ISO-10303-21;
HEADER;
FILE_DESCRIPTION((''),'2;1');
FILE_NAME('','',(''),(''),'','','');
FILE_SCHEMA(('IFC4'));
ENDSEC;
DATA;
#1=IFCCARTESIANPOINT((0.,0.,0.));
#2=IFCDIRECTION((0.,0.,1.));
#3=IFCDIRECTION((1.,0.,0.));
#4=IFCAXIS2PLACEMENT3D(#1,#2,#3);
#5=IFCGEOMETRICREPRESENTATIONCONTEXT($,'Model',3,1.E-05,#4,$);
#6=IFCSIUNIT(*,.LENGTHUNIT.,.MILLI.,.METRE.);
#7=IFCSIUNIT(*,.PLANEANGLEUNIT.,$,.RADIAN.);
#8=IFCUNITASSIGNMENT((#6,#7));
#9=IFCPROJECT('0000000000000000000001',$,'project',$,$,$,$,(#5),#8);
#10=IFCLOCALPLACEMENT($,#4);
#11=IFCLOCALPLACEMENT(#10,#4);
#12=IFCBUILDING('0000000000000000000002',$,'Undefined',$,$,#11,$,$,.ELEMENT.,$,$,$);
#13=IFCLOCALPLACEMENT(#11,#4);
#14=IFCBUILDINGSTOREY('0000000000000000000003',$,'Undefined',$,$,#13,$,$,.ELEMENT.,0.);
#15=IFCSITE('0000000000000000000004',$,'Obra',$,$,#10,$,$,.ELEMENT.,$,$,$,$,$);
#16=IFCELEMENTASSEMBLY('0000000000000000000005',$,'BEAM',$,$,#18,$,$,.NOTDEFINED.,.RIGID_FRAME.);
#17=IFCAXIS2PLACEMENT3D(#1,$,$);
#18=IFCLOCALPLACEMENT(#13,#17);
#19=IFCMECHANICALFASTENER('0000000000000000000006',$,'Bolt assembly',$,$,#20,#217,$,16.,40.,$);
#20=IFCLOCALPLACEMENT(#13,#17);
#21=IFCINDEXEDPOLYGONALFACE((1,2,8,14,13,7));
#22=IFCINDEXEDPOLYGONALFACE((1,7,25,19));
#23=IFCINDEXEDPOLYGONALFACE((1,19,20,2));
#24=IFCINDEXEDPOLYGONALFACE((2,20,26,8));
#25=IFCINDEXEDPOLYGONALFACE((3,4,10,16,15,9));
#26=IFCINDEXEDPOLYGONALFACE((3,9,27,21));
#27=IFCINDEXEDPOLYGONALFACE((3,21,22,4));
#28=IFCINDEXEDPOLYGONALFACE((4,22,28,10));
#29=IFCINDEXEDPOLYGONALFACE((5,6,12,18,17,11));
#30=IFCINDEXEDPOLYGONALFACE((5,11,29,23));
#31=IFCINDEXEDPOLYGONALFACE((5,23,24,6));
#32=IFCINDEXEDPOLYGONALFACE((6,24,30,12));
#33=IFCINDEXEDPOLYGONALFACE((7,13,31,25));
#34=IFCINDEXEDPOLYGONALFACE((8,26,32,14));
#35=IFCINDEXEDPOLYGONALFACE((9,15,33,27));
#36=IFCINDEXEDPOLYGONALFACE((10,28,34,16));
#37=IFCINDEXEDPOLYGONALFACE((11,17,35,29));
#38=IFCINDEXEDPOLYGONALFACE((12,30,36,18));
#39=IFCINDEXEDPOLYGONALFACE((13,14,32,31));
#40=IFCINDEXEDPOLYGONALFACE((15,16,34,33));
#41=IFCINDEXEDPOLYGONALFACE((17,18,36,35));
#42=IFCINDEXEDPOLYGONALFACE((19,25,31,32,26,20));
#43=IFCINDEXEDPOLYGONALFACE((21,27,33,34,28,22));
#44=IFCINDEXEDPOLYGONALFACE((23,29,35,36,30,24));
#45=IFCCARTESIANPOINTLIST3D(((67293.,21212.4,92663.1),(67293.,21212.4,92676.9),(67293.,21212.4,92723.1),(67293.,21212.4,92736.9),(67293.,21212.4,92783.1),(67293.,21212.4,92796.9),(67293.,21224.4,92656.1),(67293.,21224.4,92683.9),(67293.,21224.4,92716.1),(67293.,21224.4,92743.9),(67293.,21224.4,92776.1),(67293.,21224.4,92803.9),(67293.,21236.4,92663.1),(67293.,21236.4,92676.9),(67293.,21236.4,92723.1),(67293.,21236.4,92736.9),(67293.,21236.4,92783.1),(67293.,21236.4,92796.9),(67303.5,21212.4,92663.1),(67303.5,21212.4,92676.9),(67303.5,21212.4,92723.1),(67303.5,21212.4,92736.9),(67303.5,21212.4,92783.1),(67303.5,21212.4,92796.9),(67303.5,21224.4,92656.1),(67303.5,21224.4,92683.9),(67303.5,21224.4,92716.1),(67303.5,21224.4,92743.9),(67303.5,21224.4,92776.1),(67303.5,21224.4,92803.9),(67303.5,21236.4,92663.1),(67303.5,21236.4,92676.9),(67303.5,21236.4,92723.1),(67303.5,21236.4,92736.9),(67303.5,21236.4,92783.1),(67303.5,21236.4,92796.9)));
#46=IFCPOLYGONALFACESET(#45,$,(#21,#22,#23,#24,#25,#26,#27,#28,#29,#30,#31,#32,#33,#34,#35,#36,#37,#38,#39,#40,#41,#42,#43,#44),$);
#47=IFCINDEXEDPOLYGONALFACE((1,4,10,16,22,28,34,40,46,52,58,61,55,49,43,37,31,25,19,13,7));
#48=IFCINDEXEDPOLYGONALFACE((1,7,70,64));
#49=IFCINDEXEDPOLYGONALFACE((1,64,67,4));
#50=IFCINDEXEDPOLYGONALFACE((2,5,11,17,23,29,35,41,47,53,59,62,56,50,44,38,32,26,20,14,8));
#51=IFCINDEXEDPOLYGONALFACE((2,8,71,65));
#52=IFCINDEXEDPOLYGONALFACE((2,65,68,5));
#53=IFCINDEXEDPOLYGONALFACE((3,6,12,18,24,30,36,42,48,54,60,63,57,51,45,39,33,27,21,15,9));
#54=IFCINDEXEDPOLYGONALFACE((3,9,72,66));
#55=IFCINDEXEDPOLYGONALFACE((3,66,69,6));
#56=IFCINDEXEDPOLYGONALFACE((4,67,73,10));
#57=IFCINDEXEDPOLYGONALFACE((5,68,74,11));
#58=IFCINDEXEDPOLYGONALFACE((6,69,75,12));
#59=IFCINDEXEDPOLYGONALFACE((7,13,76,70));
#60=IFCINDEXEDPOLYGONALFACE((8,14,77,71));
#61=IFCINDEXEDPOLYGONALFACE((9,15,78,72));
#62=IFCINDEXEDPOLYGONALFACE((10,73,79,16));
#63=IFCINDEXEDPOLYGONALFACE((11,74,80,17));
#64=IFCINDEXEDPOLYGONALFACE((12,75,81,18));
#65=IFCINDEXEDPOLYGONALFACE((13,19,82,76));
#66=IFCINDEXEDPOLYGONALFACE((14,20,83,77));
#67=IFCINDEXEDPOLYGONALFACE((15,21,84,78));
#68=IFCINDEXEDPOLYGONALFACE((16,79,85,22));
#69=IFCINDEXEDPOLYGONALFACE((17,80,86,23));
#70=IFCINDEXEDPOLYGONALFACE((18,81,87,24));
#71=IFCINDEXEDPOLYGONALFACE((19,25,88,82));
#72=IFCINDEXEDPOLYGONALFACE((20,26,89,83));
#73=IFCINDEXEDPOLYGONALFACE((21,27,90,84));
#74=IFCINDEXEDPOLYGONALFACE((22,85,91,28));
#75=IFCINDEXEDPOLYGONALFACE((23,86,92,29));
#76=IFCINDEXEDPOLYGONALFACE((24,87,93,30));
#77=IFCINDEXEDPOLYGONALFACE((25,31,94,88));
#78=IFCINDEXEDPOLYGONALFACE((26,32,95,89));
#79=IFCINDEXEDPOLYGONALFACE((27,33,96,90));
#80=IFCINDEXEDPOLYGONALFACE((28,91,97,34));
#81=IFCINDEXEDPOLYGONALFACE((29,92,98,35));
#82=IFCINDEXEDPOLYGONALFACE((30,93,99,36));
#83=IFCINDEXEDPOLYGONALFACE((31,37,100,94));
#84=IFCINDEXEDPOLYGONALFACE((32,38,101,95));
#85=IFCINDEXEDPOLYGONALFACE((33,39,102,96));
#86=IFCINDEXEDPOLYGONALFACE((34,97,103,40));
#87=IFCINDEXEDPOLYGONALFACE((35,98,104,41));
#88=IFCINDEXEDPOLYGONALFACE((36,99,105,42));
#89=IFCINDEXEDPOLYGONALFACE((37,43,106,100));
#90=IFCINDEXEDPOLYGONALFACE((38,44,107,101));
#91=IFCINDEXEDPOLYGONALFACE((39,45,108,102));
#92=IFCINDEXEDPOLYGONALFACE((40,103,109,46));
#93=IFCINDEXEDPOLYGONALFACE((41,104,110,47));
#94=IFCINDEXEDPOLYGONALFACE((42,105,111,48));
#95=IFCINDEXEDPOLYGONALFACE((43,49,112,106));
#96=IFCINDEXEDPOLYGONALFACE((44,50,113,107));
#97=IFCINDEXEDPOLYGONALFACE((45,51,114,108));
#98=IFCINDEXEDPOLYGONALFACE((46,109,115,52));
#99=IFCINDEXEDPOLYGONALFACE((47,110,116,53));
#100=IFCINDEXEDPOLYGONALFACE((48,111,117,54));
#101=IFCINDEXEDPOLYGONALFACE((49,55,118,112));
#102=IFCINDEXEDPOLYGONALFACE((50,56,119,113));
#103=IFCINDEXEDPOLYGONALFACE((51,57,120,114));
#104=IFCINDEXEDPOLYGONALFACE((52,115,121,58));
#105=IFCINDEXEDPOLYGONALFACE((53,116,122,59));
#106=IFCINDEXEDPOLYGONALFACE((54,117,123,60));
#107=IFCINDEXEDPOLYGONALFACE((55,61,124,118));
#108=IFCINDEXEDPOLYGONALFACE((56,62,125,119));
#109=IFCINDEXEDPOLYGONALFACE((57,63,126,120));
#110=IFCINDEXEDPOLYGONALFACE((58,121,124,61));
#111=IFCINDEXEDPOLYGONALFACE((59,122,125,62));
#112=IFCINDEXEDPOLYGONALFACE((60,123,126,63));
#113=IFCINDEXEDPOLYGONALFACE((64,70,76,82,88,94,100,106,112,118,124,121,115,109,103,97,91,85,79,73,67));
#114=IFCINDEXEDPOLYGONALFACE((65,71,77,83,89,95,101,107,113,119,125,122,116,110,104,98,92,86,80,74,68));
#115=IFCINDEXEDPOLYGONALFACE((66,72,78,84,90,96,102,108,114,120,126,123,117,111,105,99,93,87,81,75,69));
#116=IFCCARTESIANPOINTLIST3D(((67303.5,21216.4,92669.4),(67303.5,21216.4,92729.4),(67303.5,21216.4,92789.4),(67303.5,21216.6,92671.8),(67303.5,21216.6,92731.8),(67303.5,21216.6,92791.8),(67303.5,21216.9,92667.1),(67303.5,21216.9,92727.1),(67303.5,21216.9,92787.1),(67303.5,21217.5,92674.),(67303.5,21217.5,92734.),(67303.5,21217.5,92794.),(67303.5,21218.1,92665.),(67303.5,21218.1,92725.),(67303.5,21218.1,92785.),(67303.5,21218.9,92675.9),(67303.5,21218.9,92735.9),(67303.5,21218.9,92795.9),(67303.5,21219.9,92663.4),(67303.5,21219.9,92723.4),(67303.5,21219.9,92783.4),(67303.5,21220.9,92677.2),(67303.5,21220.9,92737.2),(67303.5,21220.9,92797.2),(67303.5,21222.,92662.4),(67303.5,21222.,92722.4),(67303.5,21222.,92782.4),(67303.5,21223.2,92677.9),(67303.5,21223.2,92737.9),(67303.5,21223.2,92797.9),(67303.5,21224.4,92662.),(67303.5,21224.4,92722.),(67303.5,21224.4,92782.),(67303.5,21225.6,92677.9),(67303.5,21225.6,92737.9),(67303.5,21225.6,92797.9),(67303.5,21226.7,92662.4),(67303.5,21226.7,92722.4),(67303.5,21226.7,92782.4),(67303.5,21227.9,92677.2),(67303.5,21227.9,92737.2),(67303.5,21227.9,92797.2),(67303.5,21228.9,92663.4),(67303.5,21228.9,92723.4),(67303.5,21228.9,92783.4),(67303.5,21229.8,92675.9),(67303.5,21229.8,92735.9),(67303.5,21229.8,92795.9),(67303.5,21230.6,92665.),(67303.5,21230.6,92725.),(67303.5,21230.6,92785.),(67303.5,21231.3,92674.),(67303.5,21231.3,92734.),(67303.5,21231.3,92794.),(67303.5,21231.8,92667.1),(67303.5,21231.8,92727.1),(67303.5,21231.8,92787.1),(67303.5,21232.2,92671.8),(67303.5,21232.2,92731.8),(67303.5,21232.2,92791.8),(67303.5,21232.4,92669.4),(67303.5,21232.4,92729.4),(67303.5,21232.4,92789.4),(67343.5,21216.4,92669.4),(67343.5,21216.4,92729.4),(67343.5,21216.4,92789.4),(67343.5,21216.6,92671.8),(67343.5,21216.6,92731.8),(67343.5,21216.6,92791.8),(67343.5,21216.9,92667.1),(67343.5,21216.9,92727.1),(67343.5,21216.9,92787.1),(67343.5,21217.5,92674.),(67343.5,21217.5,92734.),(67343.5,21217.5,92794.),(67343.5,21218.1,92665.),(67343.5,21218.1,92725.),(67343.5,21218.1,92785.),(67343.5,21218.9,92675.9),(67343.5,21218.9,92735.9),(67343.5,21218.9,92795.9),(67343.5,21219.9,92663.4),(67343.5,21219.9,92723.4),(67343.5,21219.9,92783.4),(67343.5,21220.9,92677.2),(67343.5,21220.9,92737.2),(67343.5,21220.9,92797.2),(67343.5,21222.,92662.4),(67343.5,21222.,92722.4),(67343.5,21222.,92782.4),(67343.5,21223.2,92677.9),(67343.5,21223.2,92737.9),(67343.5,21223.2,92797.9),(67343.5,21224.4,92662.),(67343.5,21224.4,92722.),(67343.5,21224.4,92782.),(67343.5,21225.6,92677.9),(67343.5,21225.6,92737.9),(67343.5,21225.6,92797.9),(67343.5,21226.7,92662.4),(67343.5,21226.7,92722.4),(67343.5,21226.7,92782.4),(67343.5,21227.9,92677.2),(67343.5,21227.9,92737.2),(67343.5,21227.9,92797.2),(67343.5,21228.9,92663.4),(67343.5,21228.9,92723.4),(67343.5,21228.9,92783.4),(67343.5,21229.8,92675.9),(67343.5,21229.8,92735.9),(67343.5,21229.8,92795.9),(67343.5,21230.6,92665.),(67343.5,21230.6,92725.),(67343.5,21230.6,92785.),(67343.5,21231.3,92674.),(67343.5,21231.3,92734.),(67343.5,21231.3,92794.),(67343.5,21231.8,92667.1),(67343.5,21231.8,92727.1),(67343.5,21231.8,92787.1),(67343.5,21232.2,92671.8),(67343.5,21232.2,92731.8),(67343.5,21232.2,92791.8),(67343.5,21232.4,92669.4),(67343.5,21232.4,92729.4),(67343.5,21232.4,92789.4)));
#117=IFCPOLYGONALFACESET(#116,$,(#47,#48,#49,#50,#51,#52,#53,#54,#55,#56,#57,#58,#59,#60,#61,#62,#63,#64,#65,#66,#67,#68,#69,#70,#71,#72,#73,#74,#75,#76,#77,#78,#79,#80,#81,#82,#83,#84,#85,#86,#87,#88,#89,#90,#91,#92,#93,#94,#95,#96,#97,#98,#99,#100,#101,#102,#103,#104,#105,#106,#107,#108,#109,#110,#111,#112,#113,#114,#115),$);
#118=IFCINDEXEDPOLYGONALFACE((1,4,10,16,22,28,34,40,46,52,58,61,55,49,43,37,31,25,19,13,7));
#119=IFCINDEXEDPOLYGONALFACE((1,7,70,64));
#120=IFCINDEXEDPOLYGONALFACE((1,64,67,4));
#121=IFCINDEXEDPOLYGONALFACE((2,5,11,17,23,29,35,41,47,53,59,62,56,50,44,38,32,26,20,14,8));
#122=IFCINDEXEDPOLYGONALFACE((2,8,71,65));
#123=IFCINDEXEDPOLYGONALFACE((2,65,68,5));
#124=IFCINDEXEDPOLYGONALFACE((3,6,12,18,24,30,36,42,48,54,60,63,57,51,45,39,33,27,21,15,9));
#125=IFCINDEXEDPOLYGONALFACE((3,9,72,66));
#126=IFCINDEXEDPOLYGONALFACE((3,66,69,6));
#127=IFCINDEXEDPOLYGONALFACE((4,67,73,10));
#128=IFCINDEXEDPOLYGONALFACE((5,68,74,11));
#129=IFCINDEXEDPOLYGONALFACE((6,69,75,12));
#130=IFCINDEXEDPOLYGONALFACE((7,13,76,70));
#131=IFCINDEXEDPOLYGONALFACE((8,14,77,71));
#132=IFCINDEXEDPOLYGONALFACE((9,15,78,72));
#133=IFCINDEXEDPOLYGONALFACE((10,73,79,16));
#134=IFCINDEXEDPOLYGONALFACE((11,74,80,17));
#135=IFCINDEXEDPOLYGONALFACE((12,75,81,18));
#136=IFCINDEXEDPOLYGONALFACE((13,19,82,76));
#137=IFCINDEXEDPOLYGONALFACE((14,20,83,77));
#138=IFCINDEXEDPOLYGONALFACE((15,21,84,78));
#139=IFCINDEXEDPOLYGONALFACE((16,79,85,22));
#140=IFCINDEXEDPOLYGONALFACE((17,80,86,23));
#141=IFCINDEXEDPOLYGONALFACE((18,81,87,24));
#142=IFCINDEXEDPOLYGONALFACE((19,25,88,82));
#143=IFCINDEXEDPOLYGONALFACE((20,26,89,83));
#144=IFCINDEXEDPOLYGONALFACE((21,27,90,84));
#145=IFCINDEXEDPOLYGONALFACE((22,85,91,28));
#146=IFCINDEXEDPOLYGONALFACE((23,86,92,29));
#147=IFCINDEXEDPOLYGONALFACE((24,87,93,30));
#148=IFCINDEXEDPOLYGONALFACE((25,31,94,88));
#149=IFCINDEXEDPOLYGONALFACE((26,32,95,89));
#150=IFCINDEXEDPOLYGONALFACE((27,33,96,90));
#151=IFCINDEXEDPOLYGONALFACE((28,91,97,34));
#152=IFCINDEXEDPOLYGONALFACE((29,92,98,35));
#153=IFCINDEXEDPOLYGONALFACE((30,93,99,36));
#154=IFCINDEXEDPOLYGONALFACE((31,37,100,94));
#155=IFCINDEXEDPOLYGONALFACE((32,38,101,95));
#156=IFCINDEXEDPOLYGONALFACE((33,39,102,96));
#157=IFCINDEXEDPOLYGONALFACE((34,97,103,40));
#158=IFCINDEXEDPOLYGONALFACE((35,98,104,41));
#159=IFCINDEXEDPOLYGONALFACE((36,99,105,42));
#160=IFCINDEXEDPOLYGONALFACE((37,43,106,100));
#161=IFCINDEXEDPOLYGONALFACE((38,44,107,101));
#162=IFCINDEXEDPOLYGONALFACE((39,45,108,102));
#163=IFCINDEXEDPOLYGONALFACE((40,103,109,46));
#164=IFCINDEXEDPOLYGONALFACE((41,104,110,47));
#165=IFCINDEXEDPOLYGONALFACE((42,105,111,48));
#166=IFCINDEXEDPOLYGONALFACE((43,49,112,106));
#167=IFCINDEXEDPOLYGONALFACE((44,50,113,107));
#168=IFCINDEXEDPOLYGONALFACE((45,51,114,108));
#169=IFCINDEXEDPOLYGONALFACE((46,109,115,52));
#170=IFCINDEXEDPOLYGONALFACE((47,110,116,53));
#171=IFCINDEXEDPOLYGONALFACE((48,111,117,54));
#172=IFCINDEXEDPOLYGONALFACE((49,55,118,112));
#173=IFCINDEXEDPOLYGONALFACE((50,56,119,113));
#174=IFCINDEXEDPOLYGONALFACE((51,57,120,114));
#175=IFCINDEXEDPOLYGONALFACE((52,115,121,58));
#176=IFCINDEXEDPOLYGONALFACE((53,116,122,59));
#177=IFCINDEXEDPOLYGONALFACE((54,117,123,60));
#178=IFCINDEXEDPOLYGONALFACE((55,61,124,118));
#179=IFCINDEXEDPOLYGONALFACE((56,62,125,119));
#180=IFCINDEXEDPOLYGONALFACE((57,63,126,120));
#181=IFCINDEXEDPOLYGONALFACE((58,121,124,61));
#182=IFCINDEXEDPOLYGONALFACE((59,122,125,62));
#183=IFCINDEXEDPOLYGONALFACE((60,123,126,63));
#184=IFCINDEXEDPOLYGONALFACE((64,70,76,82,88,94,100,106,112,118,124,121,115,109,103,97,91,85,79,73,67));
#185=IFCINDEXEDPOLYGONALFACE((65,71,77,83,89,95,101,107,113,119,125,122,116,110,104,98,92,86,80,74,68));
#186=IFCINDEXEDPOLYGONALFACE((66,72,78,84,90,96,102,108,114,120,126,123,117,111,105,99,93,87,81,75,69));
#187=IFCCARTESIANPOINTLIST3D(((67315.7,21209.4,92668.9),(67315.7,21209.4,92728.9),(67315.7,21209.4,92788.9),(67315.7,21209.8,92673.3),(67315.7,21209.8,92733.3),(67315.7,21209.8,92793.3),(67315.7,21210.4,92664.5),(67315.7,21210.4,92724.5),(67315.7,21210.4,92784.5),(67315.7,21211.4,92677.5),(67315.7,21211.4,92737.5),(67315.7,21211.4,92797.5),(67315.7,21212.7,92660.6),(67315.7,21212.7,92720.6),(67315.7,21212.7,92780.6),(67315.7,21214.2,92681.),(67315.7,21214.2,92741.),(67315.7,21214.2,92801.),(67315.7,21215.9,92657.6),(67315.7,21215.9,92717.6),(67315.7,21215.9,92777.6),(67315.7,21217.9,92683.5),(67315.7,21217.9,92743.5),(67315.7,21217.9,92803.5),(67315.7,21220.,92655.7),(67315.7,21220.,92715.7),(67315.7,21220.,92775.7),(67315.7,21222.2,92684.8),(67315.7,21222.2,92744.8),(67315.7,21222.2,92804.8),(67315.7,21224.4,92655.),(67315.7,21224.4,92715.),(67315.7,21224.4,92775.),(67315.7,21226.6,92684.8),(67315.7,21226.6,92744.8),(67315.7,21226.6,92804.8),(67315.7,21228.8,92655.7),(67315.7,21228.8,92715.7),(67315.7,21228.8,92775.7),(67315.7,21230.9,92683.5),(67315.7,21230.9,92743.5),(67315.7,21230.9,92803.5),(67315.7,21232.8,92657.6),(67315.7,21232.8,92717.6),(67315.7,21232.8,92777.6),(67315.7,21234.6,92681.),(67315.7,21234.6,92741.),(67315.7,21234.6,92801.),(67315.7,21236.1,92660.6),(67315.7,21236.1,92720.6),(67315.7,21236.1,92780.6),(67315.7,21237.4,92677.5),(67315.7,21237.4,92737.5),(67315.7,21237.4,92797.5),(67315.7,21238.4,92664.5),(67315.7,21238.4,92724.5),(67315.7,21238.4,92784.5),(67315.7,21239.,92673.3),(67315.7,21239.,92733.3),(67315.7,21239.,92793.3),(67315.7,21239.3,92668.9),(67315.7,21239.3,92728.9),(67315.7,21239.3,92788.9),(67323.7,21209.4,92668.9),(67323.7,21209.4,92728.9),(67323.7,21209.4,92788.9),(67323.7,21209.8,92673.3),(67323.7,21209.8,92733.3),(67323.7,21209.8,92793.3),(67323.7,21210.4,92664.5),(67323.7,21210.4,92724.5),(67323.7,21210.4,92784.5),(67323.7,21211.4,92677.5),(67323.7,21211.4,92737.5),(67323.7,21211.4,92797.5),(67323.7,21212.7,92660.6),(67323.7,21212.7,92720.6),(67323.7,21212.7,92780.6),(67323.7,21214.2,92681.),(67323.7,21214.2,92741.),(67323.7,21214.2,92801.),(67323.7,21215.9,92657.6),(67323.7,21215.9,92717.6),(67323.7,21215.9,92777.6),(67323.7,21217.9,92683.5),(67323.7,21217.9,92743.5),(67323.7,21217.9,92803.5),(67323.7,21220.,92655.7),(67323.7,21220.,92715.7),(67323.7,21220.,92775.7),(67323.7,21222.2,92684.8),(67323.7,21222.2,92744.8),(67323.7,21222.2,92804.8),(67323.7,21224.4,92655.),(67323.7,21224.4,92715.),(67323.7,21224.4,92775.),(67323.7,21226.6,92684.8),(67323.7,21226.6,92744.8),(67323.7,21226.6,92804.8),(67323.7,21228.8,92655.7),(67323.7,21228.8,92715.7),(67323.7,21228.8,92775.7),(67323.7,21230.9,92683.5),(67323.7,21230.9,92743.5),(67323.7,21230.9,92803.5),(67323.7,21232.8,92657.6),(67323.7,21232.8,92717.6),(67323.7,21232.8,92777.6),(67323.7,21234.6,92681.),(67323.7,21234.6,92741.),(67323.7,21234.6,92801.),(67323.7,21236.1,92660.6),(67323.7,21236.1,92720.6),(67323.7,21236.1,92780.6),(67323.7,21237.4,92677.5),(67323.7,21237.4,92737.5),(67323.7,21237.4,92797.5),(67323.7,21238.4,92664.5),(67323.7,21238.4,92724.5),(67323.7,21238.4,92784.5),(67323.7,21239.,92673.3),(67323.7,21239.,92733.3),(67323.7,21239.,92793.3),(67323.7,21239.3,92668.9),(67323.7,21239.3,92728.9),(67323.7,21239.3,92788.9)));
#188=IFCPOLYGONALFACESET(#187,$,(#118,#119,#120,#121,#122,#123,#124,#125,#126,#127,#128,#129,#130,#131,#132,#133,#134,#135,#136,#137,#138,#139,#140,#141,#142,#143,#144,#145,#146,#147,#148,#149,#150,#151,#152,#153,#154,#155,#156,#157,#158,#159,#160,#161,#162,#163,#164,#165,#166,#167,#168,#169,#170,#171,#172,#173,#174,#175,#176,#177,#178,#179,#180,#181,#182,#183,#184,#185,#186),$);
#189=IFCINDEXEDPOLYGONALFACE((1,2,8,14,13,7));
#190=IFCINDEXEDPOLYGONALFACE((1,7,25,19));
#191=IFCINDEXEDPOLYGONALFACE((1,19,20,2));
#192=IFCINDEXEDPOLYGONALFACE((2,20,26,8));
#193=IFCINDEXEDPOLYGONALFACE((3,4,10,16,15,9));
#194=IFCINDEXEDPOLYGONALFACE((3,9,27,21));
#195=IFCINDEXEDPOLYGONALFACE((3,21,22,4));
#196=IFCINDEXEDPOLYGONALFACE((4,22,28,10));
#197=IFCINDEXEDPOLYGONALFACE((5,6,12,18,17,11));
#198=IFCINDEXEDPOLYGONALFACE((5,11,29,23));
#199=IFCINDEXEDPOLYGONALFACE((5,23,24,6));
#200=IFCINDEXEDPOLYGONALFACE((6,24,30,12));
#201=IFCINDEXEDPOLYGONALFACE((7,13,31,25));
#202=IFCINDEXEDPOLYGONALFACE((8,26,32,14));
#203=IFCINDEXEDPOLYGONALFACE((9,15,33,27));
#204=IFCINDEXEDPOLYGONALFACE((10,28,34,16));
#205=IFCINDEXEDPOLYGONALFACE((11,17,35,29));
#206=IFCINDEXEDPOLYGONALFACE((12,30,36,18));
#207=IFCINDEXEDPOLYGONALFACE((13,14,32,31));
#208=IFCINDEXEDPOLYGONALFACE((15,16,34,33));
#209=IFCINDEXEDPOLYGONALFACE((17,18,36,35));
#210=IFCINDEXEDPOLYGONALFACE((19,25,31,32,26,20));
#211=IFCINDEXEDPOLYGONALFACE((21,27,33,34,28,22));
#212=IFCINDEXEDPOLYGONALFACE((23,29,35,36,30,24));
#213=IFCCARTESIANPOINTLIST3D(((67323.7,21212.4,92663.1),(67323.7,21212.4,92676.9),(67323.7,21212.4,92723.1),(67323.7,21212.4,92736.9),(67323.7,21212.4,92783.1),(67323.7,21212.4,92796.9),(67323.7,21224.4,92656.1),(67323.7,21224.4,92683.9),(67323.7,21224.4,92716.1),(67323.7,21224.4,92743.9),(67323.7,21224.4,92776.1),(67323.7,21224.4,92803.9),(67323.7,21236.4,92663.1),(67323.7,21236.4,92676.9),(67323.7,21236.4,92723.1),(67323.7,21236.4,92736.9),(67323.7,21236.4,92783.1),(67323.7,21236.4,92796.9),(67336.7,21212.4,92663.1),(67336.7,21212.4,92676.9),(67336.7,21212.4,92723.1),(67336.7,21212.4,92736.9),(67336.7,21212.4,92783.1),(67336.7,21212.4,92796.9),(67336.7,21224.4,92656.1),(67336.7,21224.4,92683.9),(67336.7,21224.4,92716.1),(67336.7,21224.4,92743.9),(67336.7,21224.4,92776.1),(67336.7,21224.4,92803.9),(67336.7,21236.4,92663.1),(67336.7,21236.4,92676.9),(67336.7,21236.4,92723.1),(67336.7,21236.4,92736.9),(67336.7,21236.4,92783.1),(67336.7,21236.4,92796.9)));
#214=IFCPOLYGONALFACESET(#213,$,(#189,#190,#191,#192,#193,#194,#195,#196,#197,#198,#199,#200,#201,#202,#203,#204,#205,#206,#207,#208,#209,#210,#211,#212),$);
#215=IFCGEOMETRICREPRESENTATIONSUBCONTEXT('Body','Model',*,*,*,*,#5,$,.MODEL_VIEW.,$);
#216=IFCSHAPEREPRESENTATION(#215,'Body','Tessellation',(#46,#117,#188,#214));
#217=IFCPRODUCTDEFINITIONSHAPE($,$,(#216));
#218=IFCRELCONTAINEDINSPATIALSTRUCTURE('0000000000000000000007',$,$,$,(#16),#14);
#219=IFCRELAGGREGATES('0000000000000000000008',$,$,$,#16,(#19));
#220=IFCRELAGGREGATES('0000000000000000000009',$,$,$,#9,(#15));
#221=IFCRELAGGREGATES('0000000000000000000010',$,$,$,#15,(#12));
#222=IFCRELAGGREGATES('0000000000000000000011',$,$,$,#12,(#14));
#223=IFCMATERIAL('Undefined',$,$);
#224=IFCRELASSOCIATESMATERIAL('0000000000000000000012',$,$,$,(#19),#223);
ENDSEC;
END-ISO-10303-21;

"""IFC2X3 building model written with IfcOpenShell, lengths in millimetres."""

from ifc_helpers import new_model, si_unit, frame, origin_with_axes, origin_2d_with_axis, place, context, subcontext, project, spatial, polyline, circle, outline, extrude, source, transform, mapped, material, element, aggregate, save


model = new_model("IFC2X3")

# Units and contexts
model_context = context("Model", 3, precision=1e-05, world=origin_with_axes())
body_context = subcontext(model_context, "Body", "Model", "MODEL_VIEW")
ifc_project = project(units=[si_unit("LENGTHUNIT", "METRE", prefix="MILLI"), si_unit("PLANEANGLEUNIT", "RADIAN")], contexts=[model_context])

# Site, building, storey
site_placement = place(None, origin_with_axes())
site = spatial("IfcSite", under=ifc_project, at=site_placement, Name="Obra", CompositionType="ELEMENT")
building_placement = place(site_placement, origin_with_axes())
building = spatial("IfcBuilding", under=site, at=building_placement, Name="Undefined", CompositionType="ELEMENT")
storey_placement = place(building_placement, origin_with_axes())
storey = spatial("IfcBuildingStorey", under=building, at=storey_placement, Name="Undefined", CompositionType="ELEMENT", Elevation=0.0)

# Shared definitions
ifc_material_1 = material(Name="Undefined")

# Element assembly
shared_shape_1 = source(origin_with_axes(), body_context, "Body", "SweptSolid", [
    extrude(outline(polyline([(13.9, 0.0), (6.9, 12.0), (-6.9, 12.0), (-13.9, 0.0), (-6.9, -12.0), (6.9, -12.0), (13.9, 0.0)])), frame((0.0, -19.7, 0.0), z_axis=(0.0, 1.0, 0.0), x_axis=(1.0, 0.0, 0.0)), (0.0, 0.0, 1.0), 10.6),
    extrude(circle(Radius=8.0, at=origin_2d_with_axis()), frame((0.0, -9.1, 0.0), z_axis=(0.0, 1.0, 0.0), x_axis=(1.0, 0.0, 0.0)), (0.0, 0.0, 1.0), 40.0),
    extrude(circle(Radius=15.0, at=origin_2d_with_axis()), frame((0.0, 3.1, 0.0), z_axis=(0.0, 1.0, 0.0), x_axis=(1.0, 0.0, 0.0)), (0.0, 0.0, 1.0), 8.0),
    extrude(outline(polyline([(13.9, 0.0), (6.9, 12.0), (-6.9, 12.0), (-13.9, 0.0), (-6.9, -12.0), (6.9, -12.0), (13.9, 0.0)])), frame((0.0, 11.1, 0.0), z_axis=(0.0, 1.0, 0.0), x_axis=(1.0, 0.0, 0.0)), (0.0, 0.0, 1.0), 13.0),
])
assembly_1_placement = place(storey_placement, origin_with_axes())
assembly_1 = element("IfcElementAssembly", 1, at=assembly_1_placement, inside=storey, Name="BEAM", AssemblyPlace="NOTDEFINED", PredefinedType="RIGID_FRAME")

# Mechanical fastener
mechanical_fastener_1_placement = place(assembly_1_placement, frame((67312.6, 21274.4, 92850.0), z_axis=(0.000002, -1.0, 0.0), x_axis=(0.0, 0.0, -1.0)))
mechanical_fastener_1 = element("IfcMechanicalFastener", 2, at=mechanical_fastener_1_placement, material=ifc_material_1, Name="Bolt assembly", NominalDiameter=16.0, NominalLength=40.0, context=body_context, shape_type="MappedRepresentation", body=[
    mapped(shared_shape_1, transform((60.0, 0.0, 50.0))),
    mapped(shared_shape_1, transform((120.0, 0.0, 50.0))),
    mapped(shared_shape_1, transform((180.0, 0.0, 50.0))),
])
aggregate(assembly_1, [mechanical_fastener_1])

save(model, "model.ifc")
